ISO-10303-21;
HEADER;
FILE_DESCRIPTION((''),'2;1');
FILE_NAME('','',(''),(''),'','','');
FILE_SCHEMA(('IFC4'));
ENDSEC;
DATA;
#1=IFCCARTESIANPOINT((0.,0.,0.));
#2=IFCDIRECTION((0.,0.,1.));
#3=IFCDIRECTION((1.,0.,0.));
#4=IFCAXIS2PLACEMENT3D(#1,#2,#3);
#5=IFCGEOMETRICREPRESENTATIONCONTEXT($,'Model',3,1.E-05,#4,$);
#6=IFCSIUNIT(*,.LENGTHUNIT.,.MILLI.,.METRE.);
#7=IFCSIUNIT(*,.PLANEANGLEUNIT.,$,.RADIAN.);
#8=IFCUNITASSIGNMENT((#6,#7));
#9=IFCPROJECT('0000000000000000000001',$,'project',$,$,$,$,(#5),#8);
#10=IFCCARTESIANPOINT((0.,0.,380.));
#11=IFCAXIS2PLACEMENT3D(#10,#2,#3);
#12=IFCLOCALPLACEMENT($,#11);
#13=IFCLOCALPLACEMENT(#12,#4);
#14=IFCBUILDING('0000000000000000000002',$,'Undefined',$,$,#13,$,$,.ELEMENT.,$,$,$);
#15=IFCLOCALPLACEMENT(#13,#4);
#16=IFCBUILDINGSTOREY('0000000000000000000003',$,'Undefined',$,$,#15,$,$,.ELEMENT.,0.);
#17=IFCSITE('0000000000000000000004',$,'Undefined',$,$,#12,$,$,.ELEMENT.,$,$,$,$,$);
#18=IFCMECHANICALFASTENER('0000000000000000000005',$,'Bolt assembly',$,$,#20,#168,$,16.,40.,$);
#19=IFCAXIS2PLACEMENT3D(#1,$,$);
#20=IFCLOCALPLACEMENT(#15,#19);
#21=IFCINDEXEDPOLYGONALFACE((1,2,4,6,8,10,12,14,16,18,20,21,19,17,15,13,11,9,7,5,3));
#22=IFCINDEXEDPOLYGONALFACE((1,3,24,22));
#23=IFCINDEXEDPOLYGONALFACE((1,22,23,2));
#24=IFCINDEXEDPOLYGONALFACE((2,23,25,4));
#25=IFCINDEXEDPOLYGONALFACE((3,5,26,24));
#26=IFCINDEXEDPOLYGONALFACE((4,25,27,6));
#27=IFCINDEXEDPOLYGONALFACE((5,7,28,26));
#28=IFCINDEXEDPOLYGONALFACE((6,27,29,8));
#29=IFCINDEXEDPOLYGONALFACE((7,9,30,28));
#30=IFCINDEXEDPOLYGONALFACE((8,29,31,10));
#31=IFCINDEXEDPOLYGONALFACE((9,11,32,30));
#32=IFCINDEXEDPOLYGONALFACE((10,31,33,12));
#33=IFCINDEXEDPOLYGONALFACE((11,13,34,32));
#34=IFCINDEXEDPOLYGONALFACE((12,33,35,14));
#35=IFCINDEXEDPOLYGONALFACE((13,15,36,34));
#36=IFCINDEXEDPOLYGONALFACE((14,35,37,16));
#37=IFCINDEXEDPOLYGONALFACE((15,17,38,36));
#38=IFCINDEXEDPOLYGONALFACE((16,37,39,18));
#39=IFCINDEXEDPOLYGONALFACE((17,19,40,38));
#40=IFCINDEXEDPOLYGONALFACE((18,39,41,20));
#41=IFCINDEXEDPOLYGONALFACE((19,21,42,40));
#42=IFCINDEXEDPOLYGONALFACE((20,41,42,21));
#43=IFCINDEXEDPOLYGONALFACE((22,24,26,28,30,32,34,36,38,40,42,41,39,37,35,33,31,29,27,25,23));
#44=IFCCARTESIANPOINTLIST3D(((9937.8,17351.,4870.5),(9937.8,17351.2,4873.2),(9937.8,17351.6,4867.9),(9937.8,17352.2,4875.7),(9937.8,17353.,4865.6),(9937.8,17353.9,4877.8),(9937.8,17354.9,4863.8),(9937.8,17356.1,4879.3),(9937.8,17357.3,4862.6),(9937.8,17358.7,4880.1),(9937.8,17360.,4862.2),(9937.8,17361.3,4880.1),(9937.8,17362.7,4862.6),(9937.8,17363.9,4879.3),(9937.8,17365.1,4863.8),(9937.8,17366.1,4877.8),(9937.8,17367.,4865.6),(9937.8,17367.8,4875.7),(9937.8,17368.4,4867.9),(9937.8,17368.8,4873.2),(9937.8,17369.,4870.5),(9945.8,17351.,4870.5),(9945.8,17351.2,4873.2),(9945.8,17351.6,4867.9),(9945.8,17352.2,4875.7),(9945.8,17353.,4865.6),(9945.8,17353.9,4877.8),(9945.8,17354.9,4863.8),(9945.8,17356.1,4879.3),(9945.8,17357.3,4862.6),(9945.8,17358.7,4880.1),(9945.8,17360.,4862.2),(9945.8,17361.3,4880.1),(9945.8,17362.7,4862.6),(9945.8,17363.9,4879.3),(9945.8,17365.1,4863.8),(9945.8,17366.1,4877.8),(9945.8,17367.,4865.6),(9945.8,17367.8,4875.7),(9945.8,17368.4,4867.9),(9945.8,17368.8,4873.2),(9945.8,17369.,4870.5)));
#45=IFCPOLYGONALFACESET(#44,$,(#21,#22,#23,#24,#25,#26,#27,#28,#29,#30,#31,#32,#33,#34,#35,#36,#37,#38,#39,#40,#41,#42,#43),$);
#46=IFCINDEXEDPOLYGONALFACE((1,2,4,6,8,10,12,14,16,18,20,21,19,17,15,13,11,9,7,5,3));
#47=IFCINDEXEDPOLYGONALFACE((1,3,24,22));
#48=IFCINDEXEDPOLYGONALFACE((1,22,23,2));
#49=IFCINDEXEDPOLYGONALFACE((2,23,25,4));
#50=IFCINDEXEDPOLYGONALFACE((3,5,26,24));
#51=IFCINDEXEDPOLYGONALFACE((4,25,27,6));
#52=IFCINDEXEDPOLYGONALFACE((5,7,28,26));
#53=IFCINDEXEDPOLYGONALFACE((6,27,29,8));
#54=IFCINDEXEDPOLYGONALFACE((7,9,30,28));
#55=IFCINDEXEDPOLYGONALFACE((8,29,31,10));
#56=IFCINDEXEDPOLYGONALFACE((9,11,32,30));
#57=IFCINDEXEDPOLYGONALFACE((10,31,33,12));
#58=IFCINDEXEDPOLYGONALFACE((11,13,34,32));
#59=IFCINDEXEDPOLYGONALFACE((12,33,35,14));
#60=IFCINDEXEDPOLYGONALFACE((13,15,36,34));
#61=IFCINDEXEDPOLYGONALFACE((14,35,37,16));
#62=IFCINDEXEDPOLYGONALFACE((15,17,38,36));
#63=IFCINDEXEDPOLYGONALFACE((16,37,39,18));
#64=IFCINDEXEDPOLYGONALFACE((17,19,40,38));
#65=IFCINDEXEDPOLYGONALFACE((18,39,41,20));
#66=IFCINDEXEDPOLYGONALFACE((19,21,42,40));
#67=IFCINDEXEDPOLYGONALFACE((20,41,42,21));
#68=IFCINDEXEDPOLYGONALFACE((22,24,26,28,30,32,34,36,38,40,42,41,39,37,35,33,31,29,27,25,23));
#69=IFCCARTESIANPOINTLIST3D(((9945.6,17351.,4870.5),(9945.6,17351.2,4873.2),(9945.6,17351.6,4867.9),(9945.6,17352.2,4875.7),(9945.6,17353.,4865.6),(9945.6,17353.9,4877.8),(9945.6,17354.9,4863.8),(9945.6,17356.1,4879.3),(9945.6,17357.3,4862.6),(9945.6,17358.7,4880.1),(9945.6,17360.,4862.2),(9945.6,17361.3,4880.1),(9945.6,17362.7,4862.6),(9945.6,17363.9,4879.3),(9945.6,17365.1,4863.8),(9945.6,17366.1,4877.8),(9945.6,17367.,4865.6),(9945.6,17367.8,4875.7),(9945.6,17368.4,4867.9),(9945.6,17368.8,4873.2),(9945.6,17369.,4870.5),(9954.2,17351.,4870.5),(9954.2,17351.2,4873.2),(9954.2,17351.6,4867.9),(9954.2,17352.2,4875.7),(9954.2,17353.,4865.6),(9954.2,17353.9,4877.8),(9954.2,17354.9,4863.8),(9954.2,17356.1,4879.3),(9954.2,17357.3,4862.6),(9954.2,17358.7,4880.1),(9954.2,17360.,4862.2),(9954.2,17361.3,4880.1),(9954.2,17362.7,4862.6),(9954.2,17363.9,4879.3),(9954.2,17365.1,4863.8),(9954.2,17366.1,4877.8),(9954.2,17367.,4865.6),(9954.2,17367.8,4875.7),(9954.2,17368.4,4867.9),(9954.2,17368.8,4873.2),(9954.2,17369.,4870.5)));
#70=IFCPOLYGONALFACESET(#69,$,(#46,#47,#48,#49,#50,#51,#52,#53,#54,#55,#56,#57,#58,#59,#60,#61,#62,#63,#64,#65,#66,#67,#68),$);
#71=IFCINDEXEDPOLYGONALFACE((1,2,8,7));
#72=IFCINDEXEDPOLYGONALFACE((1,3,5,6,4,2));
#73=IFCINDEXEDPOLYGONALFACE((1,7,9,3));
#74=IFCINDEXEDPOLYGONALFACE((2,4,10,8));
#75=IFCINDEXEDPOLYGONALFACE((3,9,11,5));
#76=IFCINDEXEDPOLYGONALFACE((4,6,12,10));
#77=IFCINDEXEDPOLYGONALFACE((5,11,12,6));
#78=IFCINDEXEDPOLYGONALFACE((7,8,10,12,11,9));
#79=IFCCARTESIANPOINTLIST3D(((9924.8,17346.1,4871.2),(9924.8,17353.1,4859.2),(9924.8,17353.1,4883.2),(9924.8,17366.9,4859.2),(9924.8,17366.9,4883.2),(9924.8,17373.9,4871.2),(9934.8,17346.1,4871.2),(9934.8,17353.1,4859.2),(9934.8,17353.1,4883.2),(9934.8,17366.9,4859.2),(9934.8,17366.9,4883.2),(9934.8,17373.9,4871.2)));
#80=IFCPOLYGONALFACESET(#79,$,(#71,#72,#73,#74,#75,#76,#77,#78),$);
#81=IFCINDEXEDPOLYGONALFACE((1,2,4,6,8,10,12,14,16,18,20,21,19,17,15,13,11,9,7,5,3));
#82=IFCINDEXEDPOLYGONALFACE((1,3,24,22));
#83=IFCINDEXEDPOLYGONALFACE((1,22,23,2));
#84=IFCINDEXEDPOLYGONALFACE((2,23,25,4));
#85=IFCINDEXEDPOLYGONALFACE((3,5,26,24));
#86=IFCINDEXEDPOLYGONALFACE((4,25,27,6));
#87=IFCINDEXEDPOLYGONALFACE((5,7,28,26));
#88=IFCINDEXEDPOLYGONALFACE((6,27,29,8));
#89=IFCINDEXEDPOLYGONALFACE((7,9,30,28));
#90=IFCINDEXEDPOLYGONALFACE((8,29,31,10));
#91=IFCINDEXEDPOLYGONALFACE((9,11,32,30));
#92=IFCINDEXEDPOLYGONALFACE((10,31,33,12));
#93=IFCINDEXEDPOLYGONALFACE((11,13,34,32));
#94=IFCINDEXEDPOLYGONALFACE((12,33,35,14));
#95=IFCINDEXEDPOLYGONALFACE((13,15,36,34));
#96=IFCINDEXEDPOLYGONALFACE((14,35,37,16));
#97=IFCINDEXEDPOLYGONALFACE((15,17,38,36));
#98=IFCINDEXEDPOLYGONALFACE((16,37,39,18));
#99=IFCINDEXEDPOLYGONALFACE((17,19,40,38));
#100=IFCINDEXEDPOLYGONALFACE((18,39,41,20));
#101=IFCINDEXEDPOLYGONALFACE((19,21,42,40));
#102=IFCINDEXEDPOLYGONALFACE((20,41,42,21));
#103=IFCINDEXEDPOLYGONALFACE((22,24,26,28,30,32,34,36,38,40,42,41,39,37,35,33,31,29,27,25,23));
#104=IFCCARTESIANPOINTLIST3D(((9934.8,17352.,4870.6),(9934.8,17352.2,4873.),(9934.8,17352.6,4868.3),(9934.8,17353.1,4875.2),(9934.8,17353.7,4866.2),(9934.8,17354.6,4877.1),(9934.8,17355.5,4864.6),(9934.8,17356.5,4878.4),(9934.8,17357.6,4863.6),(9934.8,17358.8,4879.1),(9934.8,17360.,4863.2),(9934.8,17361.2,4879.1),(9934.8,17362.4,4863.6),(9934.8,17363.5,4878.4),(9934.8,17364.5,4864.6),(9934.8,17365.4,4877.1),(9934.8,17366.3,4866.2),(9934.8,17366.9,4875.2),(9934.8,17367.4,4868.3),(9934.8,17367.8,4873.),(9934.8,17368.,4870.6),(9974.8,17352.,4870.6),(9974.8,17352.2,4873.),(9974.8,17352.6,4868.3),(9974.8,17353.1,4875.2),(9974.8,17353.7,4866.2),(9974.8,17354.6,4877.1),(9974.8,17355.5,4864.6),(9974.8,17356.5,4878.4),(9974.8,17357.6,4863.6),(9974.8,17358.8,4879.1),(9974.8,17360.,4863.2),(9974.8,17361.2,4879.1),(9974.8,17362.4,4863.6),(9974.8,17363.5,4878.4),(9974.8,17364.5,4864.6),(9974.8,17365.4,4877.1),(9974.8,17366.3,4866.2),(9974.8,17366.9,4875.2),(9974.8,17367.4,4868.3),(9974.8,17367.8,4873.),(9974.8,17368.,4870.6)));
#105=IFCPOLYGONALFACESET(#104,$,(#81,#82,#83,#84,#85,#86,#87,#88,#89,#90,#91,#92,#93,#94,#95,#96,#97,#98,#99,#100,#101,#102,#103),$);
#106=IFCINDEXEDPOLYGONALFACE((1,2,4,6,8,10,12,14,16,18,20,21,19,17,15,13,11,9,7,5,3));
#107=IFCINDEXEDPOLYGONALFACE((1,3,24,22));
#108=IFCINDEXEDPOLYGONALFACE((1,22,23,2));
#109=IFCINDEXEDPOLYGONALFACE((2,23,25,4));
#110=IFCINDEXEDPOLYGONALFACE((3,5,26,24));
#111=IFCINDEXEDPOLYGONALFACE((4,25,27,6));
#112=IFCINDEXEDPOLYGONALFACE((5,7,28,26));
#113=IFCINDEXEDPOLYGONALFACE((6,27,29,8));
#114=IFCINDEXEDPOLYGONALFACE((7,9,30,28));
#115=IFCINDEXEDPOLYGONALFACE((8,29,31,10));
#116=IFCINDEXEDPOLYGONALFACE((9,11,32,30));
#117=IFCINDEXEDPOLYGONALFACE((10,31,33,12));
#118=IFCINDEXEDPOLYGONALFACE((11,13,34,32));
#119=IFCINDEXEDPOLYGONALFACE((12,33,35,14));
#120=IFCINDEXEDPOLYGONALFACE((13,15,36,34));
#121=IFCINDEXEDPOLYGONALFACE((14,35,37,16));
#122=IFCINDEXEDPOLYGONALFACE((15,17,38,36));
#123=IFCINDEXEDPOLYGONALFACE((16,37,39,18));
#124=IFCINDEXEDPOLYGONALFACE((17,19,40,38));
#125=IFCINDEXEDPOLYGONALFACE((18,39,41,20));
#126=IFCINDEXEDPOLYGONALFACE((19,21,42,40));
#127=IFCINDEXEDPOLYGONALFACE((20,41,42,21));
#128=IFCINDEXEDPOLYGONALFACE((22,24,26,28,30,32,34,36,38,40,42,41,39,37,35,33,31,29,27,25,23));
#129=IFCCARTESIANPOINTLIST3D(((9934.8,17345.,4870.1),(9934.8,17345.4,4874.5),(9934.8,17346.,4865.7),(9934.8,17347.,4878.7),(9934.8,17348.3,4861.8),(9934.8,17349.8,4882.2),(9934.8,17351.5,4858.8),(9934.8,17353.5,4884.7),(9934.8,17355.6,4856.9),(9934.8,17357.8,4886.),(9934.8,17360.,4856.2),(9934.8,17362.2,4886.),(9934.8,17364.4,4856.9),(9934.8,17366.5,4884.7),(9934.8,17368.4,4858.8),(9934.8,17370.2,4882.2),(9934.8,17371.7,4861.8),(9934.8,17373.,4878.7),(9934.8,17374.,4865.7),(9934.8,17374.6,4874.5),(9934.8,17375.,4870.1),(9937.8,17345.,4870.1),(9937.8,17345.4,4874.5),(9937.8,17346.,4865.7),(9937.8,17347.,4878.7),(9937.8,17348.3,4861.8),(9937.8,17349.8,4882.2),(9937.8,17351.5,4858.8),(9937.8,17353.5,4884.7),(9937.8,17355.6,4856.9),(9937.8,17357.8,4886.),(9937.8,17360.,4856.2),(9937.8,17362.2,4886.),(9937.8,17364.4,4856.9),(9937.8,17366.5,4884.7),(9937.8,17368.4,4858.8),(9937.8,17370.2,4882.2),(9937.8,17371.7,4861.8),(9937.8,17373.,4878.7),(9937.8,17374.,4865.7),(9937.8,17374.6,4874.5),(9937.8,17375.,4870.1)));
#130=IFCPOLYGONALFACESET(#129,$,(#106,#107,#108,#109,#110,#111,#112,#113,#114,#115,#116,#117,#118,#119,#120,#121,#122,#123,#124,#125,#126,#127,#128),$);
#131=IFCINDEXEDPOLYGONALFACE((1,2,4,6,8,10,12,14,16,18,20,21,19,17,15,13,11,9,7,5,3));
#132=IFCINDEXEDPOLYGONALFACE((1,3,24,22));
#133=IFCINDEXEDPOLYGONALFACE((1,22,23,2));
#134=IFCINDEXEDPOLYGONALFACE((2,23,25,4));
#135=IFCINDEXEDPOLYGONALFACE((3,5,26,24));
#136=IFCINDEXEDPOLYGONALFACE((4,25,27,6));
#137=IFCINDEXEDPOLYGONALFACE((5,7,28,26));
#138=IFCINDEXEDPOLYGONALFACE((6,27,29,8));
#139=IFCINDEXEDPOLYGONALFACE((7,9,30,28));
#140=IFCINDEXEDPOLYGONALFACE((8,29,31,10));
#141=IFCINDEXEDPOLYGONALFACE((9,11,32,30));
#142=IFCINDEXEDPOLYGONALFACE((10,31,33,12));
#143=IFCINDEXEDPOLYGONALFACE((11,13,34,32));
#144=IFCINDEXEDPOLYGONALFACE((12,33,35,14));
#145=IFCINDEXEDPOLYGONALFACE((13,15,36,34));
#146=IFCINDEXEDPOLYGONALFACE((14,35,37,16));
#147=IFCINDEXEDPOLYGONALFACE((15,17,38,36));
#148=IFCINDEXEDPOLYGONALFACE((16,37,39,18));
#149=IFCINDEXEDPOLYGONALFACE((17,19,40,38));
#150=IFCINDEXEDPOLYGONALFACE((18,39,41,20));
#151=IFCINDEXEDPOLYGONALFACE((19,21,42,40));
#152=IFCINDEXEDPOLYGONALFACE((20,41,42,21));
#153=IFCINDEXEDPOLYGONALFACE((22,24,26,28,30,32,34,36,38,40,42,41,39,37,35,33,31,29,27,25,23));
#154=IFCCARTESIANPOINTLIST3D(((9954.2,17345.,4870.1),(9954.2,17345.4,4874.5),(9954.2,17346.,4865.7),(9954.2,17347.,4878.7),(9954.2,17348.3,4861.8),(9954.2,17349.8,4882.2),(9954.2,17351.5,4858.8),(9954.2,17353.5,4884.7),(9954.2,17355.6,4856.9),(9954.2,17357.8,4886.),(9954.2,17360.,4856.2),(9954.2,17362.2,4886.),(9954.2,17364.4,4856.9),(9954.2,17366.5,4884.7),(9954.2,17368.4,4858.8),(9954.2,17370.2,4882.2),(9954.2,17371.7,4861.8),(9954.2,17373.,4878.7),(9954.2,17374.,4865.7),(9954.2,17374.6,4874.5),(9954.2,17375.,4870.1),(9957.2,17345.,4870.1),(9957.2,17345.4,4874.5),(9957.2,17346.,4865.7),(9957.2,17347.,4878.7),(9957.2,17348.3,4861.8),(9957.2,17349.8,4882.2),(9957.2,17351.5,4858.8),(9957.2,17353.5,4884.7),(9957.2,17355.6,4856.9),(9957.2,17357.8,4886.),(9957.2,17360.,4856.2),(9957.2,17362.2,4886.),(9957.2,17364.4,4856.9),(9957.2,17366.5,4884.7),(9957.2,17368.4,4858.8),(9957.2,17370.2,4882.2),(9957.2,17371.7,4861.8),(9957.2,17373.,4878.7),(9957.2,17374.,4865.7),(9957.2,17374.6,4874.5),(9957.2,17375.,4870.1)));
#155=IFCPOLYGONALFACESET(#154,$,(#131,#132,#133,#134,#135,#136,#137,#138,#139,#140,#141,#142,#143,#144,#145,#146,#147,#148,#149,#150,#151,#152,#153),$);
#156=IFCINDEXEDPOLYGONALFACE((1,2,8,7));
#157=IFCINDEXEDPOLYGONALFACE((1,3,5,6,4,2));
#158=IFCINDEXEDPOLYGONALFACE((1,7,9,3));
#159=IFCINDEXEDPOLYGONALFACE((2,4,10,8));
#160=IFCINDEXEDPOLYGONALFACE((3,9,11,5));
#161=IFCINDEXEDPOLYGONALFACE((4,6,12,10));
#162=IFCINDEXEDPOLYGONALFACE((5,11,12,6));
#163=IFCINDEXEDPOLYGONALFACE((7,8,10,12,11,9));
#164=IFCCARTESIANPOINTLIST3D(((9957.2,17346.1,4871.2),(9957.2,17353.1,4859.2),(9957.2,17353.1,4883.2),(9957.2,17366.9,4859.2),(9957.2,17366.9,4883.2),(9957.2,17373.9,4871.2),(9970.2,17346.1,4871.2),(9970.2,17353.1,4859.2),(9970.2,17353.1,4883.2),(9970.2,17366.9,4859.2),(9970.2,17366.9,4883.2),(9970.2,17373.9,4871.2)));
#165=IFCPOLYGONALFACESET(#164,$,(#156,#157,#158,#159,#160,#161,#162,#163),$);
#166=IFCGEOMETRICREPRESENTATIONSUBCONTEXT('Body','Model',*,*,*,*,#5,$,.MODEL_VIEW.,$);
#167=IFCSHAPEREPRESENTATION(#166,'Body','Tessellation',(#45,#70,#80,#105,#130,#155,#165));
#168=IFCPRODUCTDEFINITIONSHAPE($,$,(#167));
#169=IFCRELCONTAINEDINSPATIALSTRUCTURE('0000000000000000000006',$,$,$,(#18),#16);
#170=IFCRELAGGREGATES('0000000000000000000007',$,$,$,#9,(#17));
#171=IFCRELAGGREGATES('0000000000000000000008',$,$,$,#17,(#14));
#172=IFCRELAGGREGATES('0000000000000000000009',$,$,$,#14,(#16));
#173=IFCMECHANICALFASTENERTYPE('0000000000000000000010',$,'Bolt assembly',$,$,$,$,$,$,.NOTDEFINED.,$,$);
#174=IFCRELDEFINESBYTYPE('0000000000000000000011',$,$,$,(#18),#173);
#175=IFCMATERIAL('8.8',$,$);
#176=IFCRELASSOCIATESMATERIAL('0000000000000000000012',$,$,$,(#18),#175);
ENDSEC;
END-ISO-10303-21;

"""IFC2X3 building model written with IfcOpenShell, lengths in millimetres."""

from ifc_helpers import new_model, si_unit, frame, origin_with_axes, origin_2d_with_axis, place, context, subcontext, project, spatial, polyline, circle, outline, extrude, source, transform, mapped, material, type_object, element, save


model = new_model("IFC2X3")

# Units and contexts
model_context = context("Model", 3, precision=1e-05, world=origin_with_axes())
body_context = subcontext(model_context, "Body", "Model", "MODEL_VIEW")
ifc_project = project(units=[si_unit("LENGTHUNIT", "METRE", prefix="MILLI"), si_unit("PLANEANGLEUNIT", "RADIAN")], contexts=[model_context])

# Site, building, storey
site_placement = place(None, frame((0.0, 0.0, 380.0), z_axis=(0.0, 0.0, 1.0), x_axis=(1.0, 0.0, 0.0)))
site = spatial("IfcSite", under=ifc_project, at=site_placement, Name="Undefined", CompositionType="ELEMENT")
building_placement = place(site_placement, origin_with_axes())
building = spatial("IfcBuilding", under=site, at=building_placement, Name="Undefined", CompositionType="ELEMENT")
storey_placement = place(building_placement, origin_with_axes())
storey = spatial("IfcBuildingStorey", under=building, at=storey_placement, Name="Undefined", CompositionType="ELEMENT", Elevation=0.0)

# Mechanical fastener
ifc_material_1 = material(Name="8.8")
mechanical_fastener_type = type_object("IfcMechanicalFastenerType", Name="Bolt assembly")
shared_shape_1 = source(origin_with_axes(), body_context, "Body", "SweptSolid", [
    extrude(circle(Radius=9.0, at=origin_2d_with_axis()), frame((0.0, -7.9, 0.0), z_axis=(0.0, 1.0, 0.0), x_axis=(1.0, 0.0, 0.0)), (0.0, 0.0, 1.0), 8.0),
    extrude(circle(Radius=9.0, at=origin_2d_with_axis()), frame((0.0, -0.1, 0.0), z_axis=(0.0, 1.0, 0.0), x_axis=(1.0, 0.0, 0.0)), (0.0, 0.0, 1.0), 8.6),
    extrude(outline(polyline([(12.0, -6.9), (12.0, 6.9), (0.0, 13.9), (-12.0, 6.9), (-12.0, -6.9), (0.0, -13.9), (12.0, -6.9)])), frame((0.0, -21.0, 0.0), z_axis=(0.0, 1.0, 0.0), x_axis=(1.0, 0.0, 0.0)), (0.0, 0.0, 1.0), 10.0),
    extrude(circle(Radius=8.0, at=origin_2d_with_axis()), frame((0.0, -11.0, 0.0), z_axis=(0.0, 1.0, 0.0), x_axis=(1.0, 0.0, 0.0)), (0.0, 0.0, 1.0), 40.0),
    extrude(circle(Radius=15.0, at=origin_2d_with_axis()), frame((0.0, -11.0, 0.0), z_axis=(0.0, 1.0, 0.0), x_axis=(1.0, 0.0, 0.0)), (0.0, 0.0, 1.0), 3.0),
    extrude(circle(Radius=15.0, at=origin_2d_with_axis()), frame((0.0, 8.5, 0.0), z_axis=(0.0, 1.0, 0.0), x_axis=(1.0, 0.0, 0.0)), (0.0, 0.0, 1.0), 3.0),
    extrude(outline(polyline([(12.0, -6.9), (12.0, 6.9), (0.0, 13.9), (-12.0, 6.9), (-12.0, -6.9), (0.0, -13.9), (12.0, -6.9)])), frame((0.0, 11.5, 0.0), z_axis=(0.0, 1.0, 0.0), x_axis=(1.0, 0.0, 0.0)), (0.0, 0.0, 1.0), 13.0),
])
for number, where, z_axis, x_axis, name in (
    (1, (9945.8, 17397.5, 4951.2), (0.0, -1.0, 0.0), (0.0, 0.0, -1.0), "Bolt assembly"),
):
    element("IfcMechanicalFastener", number, at=place(storey_placement, frame(where, z_axis=z_axis, x_axis=x_axis)), inside=storey, type_object=mechanical_fastener_type, material=ifc_material_1, Name=name, NominalDiameter=16.0, NominalLength=40.0, context=body_context, shape_type="MappedRepresentation", body=[
        mapped(shared_shape_1, transform((80.0, 0.0, 37.5))),
    ])

save(model, "model.ifc")
